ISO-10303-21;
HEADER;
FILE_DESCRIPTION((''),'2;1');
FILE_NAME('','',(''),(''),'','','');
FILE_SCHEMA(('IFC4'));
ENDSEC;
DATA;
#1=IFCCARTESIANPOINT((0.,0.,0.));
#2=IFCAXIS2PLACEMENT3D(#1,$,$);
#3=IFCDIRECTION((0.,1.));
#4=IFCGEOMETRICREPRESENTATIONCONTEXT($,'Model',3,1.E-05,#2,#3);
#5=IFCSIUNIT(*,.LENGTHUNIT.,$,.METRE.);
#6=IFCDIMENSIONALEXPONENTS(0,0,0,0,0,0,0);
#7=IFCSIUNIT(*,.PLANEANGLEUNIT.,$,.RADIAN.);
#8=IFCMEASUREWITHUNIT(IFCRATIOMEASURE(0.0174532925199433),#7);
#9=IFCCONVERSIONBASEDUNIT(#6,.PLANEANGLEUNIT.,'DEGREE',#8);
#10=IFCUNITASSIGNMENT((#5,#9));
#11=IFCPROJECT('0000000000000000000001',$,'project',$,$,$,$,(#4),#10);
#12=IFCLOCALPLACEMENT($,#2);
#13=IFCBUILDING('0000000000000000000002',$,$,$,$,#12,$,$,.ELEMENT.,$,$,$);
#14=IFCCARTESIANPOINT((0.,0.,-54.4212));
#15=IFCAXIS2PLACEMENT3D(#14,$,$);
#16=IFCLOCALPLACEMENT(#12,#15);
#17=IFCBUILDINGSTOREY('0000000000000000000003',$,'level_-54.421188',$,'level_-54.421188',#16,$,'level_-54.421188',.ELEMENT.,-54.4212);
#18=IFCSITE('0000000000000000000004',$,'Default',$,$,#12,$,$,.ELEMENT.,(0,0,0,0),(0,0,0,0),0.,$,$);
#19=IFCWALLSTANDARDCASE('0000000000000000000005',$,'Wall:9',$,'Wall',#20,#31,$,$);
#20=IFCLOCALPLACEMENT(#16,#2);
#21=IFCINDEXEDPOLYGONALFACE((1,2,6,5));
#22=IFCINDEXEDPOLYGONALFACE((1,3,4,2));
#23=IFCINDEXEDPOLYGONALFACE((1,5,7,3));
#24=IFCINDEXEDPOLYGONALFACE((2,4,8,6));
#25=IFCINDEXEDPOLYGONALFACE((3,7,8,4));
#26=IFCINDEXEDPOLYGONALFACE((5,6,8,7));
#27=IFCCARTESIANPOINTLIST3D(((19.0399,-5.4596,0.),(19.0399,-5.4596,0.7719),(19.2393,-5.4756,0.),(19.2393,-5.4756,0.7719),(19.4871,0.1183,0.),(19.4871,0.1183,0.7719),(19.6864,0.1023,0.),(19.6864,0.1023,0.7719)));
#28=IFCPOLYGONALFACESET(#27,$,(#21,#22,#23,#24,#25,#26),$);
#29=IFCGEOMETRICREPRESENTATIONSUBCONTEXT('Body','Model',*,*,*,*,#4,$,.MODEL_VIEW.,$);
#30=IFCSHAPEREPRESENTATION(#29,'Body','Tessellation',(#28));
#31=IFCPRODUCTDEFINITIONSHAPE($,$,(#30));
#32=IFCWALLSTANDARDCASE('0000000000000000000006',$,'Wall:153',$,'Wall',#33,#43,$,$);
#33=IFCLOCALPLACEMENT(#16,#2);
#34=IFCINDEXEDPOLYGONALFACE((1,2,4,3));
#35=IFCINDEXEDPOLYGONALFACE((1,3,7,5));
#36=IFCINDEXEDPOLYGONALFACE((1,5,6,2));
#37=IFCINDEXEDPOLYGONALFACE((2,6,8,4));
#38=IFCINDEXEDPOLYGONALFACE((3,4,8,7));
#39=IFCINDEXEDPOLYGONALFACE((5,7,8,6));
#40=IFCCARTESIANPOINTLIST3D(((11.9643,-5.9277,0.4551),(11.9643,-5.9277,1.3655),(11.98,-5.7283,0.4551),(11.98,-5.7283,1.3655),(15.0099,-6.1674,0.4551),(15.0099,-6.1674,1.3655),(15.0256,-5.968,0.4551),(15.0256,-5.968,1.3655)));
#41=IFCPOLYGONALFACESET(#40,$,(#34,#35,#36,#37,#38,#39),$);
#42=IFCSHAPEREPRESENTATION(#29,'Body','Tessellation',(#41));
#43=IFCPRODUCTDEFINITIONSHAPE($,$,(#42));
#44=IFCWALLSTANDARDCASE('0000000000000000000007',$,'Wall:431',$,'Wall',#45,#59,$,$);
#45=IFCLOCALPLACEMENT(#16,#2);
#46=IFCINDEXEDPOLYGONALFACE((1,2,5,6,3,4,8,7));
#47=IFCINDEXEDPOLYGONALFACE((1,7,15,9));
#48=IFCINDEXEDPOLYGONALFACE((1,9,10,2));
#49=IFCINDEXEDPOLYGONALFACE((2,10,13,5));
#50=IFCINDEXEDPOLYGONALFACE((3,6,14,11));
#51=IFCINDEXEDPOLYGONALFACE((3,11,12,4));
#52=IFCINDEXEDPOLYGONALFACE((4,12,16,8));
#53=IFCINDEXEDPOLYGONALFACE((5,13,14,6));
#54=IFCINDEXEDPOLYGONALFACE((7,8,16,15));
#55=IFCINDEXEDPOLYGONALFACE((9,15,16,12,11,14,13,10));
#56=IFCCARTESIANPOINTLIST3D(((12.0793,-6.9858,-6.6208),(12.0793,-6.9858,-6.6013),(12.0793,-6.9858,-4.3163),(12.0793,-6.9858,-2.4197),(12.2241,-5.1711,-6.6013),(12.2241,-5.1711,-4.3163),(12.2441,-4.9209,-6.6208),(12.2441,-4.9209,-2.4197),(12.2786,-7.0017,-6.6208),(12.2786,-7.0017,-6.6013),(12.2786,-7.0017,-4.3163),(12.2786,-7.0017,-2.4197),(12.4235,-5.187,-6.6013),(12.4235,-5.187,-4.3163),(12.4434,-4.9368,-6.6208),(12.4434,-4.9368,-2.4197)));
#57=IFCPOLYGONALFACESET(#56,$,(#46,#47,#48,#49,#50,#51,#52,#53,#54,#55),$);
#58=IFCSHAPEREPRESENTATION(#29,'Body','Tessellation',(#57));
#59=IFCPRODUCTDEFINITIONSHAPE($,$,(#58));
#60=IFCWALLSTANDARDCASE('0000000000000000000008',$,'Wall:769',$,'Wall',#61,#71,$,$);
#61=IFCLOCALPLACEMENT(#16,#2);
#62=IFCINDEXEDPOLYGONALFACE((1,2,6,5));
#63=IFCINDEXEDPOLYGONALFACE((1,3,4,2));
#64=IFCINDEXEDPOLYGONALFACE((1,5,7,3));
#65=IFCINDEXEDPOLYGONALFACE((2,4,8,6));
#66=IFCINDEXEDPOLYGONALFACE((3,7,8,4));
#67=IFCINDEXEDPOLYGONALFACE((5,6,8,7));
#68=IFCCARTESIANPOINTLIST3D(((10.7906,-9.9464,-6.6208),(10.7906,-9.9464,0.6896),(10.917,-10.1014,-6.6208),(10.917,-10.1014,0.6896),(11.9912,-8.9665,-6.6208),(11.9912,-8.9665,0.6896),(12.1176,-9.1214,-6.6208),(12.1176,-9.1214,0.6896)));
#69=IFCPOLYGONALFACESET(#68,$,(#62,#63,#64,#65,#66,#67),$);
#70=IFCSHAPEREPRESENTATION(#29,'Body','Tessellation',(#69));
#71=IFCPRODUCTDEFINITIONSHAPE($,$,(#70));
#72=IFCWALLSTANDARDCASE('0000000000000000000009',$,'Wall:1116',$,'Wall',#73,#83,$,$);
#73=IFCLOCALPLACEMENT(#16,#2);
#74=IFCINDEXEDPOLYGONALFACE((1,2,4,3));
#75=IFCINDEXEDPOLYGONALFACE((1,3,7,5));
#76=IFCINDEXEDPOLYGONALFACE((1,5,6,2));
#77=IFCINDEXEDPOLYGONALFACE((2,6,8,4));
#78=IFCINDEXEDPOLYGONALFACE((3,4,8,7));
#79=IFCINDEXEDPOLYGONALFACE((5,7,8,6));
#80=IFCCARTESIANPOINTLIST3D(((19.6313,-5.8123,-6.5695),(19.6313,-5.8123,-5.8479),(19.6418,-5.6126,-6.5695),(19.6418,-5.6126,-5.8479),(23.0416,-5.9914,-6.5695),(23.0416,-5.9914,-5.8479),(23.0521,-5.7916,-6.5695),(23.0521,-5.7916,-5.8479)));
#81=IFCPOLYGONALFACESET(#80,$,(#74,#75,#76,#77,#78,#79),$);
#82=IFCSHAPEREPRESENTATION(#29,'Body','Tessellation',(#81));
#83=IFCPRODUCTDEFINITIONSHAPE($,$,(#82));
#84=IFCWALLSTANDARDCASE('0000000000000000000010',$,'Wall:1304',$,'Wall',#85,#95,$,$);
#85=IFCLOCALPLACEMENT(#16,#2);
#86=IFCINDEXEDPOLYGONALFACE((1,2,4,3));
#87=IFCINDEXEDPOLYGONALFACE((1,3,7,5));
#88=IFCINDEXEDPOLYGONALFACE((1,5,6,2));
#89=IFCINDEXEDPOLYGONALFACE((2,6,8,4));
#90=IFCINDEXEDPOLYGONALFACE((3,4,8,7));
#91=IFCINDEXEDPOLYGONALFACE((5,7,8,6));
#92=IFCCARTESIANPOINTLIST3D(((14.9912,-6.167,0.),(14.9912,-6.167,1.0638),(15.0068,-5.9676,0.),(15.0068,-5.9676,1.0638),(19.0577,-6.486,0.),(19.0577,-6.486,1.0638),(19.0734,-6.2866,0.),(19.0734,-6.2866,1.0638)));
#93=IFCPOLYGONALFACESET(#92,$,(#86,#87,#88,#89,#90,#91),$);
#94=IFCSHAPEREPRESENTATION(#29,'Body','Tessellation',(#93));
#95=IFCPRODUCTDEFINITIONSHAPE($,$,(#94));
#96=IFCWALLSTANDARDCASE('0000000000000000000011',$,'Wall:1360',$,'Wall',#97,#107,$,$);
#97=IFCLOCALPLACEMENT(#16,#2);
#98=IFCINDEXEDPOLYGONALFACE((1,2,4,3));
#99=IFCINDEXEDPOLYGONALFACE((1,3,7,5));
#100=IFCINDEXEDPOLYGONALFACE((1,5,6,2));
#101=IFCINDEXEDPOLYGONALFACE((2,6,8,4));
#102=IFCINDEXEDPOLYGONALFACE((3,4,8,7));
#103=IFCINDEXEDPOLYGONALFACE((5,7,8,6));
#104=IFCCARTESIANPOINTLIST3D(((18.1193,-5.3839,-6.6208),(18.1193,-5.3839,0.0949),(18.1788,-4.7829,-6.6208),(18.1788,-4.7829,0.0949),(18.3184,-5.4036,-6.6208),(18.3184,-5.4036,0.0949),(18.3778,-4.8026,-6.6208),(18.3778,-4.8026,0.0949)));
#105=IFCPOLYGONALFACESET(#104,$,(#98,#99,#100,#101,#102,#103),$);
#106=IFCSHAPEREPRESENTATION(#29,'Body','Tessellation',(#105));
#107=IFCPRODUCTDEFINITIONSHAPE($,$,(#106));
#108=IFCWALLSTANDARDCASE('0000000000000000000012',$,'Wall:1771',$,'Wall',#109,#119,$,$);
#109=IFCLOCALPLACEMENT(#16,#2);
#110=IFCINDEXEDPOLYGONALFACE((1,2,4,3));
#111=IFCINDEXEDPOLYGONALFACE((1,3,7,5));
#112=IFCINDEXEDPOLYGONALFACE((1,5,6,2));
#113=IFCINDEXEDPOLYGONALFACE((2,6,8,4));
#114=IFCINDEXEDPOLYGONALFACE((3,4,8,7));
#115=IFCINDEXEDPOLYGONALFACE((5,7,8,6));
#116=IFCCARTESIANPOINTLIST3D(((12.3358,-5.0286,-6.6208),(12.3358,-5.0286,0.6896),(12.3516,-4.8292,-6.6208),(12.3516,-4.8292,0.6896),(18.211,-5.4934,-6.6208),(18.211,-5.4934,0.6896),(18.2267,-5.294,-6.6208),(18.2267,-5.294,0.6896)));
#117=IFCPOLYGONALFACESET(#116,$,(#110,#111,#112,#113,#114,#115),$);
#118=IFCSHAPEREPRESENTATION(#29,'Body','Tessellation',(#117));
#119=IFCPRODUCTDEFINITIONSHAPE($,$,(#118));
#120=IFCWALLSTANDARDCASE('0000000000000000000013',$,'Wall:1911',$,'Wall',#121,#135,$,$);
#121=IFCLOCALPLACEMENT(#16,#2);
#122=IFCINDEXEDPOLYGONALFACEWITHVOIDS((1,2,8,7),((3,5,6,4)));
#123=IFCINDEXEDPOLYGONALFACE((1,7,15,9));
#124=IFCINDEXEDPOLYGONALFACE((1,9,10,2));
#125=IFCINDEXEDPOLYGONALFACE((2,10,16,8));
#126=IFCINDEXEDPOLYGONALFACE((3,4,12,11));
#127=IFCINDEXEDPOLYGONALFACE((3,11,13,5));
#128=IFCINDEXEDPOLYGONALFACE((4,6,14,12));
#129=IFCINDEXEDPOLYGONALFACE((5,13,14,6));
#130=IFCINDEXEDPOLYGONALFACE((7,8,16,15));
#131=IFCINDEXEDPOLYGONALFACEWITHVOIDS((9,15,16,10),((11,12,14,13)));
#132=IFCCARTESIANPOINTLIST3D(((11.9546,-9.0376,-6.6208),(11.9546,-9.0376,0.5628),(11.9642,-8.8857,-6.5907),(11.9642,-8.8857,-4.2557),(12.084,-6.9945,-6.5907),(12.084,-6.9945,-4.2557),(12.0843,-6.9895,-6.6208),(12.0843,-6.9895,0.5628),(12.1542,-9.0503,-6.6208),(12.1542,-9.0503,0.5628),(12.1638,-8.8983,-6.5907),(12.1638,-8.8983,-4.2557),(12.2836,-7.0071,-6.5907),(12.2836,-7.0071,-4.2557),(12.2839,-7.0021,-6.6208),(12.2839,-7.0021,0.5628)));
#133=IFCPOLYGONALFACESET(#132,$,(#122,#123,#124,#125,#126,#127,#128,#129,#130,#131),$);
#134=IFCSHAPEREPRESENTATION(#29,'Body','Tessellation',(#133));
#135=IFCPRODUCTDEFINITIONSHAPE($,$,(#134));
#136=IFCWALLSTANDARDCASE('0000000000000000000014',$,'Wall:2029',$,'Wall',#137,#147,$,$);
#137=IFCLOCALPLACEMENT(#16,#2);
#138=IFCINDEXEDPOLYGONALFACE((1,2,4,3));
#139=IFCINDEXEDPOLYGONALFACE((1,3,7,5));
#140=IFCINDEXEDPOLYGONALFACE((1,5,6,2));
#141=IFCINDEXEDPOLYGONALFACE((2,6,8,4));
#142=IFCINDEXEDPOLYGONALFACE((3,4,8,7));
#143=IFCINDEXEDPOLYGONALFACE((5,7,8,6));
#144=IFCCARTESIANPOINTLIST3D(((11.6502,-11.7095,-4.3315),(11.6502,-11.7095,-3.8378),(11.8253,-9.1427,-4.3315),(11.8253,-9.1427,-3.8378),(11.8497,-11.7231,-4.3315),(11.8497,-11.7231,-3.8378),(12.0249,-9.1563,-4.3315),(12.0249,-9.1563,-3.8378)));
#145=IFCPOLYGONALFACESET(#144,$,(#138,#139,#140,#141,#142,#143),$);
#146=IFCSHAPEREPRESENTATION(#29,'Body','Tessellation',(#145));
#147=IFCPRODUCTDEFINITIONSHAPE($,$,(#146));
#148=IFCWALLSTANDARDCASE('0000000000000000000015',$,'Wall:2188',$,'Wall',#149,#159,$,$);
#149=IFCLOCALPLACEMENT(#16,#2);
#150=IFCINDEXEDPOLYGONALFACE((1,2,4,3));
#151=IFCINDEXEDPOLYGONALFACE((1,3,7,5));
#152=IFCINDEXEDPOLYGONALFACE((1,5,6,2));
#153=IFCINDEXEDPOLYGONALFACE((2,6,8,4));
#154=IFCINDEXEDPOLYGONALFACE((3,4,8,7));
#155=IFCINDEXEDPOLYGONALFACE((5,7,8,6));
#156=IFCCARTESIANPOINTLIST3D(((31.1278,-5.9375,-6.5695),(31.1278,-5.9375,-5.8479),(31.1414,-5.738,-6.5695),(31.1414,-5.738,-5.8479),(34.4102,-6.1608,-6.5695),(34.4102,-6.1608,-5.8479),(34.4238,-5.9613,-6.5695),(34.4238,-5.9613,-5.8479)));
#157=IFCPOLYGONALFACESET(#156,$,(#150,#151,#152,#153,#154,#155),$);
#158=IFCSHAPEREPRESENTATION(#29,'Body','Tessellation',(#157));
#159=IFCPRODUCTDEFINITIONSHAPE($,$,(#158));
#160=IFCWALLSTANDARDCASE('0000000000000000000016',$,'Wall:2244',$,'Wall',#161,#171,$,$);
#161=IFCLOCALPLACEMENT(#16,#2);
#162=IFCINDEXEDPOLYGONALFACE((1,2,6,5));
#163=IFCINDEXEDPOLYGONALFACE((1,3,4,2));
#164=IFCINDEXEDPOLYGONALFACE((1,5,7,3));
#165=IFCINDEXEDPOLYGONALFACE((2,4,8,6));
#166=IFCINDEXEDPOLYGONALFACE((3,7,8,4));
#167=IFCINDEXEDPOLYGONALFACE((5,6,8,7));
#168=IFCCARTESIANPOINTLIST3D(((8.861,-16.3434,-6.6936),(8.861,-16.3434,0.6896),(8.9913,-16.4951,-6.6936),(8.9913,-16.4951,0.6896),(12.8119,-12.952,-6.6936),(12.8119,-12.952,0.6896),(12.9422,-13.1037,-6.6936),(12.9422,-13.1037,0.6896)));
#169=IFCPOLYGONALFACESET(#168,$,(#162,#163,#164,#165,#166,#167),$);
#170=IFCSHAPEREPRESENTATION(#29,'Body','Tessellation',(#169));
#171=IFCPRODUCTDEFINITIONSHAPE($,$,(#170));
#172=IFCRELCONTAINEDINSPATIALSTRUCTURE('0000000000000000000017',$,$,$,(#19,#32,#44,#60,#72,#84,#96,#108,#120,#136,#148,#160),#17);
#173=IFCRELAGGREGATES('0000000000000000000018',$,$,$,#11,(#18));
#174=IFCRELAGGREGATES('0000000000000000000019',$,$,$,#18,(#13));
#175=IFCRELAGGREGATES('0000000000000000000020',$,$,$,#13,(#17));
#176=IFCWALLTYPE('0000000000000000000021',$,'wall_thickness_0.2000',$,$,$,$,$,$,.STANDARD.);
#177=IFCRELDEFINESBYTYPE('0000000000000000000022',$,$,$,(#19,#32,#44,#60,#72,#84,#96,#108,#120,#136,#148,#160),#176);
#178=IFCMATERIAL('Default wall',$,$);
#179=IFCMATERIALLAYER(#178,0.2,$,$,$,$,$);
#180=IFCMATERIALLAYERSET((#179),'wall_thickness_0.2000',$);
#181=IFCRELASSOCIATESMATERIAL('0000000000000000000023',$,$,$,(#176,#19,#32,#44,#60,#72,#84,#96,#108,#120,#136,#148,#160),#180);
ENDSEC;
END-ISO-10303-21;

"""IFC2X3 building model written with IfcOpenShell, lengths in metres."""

from ifc_helpers import new_model, entity, si_unit, converted_unit, direction, frame, frame_2d, origin, place, context, subcontext, project, spatial, polyline, rectangle, outline, extrude, material, layer, layer_set, layer_usage, type_object, element, save


model = new_model("IFC2X3")

# Units and contexts
model_context = context("Model", 3, precision=1e-05, world=origin(), true_north=direction((0.0, 1.0)))
body_context = subcontext(model_context, "Body", "Model", "MODEL_VIEW")
ifc_project = project(units=[si_unit("LENGTHUNIT", "METRE"), converted_unit("PLANEANGLEUNIT", "DEGREE", entity("IfcRatioMeasure", 0.0174532925199433), si_unit("PLANEANGLEUNIT", "RADIAN"), dimensions=[0, 0, 0, 0, 0, 0, 0])], contexts=[model_context])

# Site, building, storey
placement_1 = place(None, origin())
site = spatial("IfcSite", under=ifc_project, at=placement_1, Name="Default", CompositionType="ELEMENT", RefLatitude=(0, 0, 0, 0), RefLongitude=(0, 0, 0, 0), RefElevation=0.0)
building = spatial("IfcBuilding", under=site, at=placement_1, CompositionType="ELEMENT")
storey_placement = place(placement_1, frame((0.0, 0.0, -54.4212)))
storey = spatial("IfcBuildingStorey", under=building, at=storey_placement, Name="level_-54.421188", ObjectType="level_-54.421188", LongName="level_-54.421188", CompositionType="ELEMENT", Elevation=-54.4212)

# Walls
ifc_material = material(Name="Default wall")
ifc_layer = layer(ifc_material, 0.2)
ifc_layer_set = layer_set([ifc_layer], Name="wall_thickness_0.2000")
ifc_layer_usage = layer_usage(ifc_layer_set, "AXIS2", "POSITIVE", -0.1)
wall_type = type_object("IfcWallType", Name="wall_thickness_0.2000", PredefinedType="STANDARD", material=ifc_layer_set)
wall_1_placement = place(storey_placement, frame((19.1396, -5.4676, 0.0), z_axis=(0.0, 0.0, 1.0), x_axis=(0.079906, 0.996802, 0.0)))
element("IfcWallStandardCase", 1, at=wall_1_placement, inside=storey, type_object=wall_type, material=ifc_layer_usage, Name="Wall:9", ObjectType="Wall", context=body_context, shape_type="SweptSolid", body=[
    extrude(outline(polyline([(5.5958, -0.1), (5.5958, 0.1), (0.0, 0.1), (0.0, -0.1), (5.5958, -0.1)])), origin(), (0.0, 0.0, 1.0), 0.7719),
])
placement_2 = place(placement_1, frame((0.0, 0.0, -53.9661)))
wall_2_placement = place(placement_2, frame((11.9722, -5.828, 0.0), z_axis=(0.0, 0.0, 1.0), x_axis=(0.996917, -0.07846, 0.0)))
element("IfcWallStandardCase", 2, at=wall_2_placement, inside=storey, type_object=wall_type, material=ifc_layer_usage, Name="Wall:153", ObjectType="Wall", context=body_context, shape_type="SweptSolid", body=[
    extrude(outline(polyline([(3.055, -0.1), (3.055, 0.1), (0.0, 0.1), (0.0, -0.1), (3.055, -0.1)])), origin(), (0.0, 0.0, 1.0), 0.9104),
])

# Wall, opening
placement_3 = place(placement_1, frame((0.0, 0.0, -61.042)))
wall_3_placement = place(placement_3, frame((12.3437, -4.9289, 0.0), z_axis=(0.0, 0.0, 1.0), x_axis=(-0.079545, -0.996831, 0.0)))
wall_3 = element("IfcWallStandardCase", 3, at=wall_3_placement, inside=storey, type_object=wall_type, material=ifc_layer_usage, Name="Wall:431", ObjectType="Wall", context=body_context, shape_type="SweptSolid", body=[
    extrude(outline(polyline([(2.0715, -0.1), (2.0715, 0.1), (0.0, 0.1), (0.0, -0.1), (2.0715, -0.1)])), origin(), (0.0, 0.0, 1.0), 4.2012),
])
opening_1_placement = place(wall_3_placement, frame((0.2509, -0.1, 0.0196)))
element("IfcOpeningElement", 4, at=opening_1_placement, cuts=wall_3, ObjectType="Opening", context=body_context, shape_type="SweptSolid", body=[
    extrude(rectangle(XDim=1.87, YDim=2.285, at=frame_2d((1.1425, 0.935), x_axis=(0.0, 1.0))), frame((0.0, 0.0, 0.0), z_axis=(0.0, 1.0, 0.0), x_axis=(0.0, 0.0, 1.0)), (0.0, 0.0, 1.0), 0.2),
])

# Walls
placement_4 = place(placement_1, frame((0.0, 0.0, -61.042)))
wall_4_placement = place(placement_4, frame((12.0544, -9.0439, 0.0), z_axis=(0.0, 0.0, 1.0), x_axis=(-0.774696, -0.632333, 0.0)))
element("IfcWallStandardCase", 5, at=wall_4_placement, inside=storey, type_object=wall_type, material=ifc_layer_usage, Name="Wall:769", ObjectType="Wall", context=body_context, shape_type="SweptSolid", body=[
    extrude(outline(polyline([(1.5498, -0.1), (1.5498, 0.1), (0.0, 0.1), (0.0, -0.1), (1.5498, -0.1)])), origin(), (0.0, 0.0, 1.0), 7.3104),
])
placement_5 = place(placement_1, frame((0.0, 0.0, -60.9907)))
wall_5_placement = place(placement_5, frame((19.6365, -5.7125, 0.0), z_axis=(0.0, 0.0, 1.0), x_axis=(0.998625, -0.052423, 0.0)))
element("IfcWallStandardCase", 6, at=wall_5_placement, inside=storey, type_object=wall_type, material=ifc_layer_usage, Name="Wall:1116", ObjectType="Wall", context=body_context, shape_type="SweptSolid", body=[
    extrude(outline(polyline([(3.415, -0.1), (3.415, 0.1), (0.0, 0.1), (0.0, -0.1), (3.415, -0.1)])), origin(), (0.0, 0.0, 1.0), 0.7215),
])
wall_6_placement = place(storey_placement, frame((14.999, -6.0673, 0.0), z_axis=(0.0, 0.0, 1.0), x_axis=(0.996939, -0.078189, 0.0)))
element("IfcWallStandardCase", 7, at=wall_6_placement, inside=storey, type_object=wall_type, material=ifc_layer_usage, Name="Wall:1304", ObjectType="Wall", context=body_context, shape_type="SweptSolid", body=[
    extrude(outline(polyline([(4.079, -0.1), (4.079, 0.1), (0.0, 0.1), (0.0, -0.1), (4.079, -0.1)])), origin(), (0.0, 0.0, 1.0), 1.0638),
])
placement_6 = place(placement_1, frame((0.0, 0.0, -61.042)))
wall_7_placement = place(placement_6, frame((18.2189, -5.3937, 0.0), z_axis=(0.0, 0.0, 1.0), x_axis=(0.098501, 0.995137, 0.0)))
element("IfcWallStandardCase", 8, at=wall_7_placement, inside=storey, type_object=wall_type, material=ifc_layer_usage, Name="Wall:1360", ObjectType="Wall", context=body_context, shape_type="SweptSolid", body=[
    extrude(outline(polyline([(0.6039, -0.1), (0.6039, 0.1), (0.0, 0.1), (0.0, -0.1), (0.6039, -0.1)])), origin(), (0.0, 0.0, 1.0), 6.7157),
])
placement_7 = place(placement_1, frame((0.0, 0.0, -61.042)))
wall_8_placement = place(placement_7, frame((18.2188, -5.3937, 0.0), z_axis=(0.0, 0.0, 1.0), x_axis=(-0.996885, 0.078873, 0.0)))
element("IfcWallStandardCase", 9, at=wall_8_placement, inside=storey, type_object=wall_type, material=ifc_layer_usage, Name="Wall:1771", ObjectType="Wall", context=body_context, shape_type="SweptSolid", body=[
    extrude(outline(polyline([(5.8935, -0.1), (5.8935, 0.1), (0.0, 0.1), (0.0, -0.1), (5.8935, -0.1)])), origin(), (0.0, 0.0, 1.0), 7.3104),
])

# Wall, opening
placement_8 = place(placement_1, frame((0.0, 0.0, -61.042)))
wall_9_placement = place(placement_8, frame((12.1841, -6.9958, 0.0), z_axis=(0.0, 0.0, 1.0), x_axis=(-0.063192, -0.998001, 0.0)))
wall_9 = element("IfcWallStandardCase", 10, at=wall_9_placement, inside=storey, type_object=wall_type, material=ifc_layer_usage, Name="Wall:1911", ObjectType="Wall", context=body_context, shape_type="SweptSolid", body=[
    extrude(outline(polyline([(2.0522, -0.1), (2.0522, 0.1), (0.0, 0.1), (0.0, -0.1), (2.0522, -0.1)])), origin(), (0.0, 0.0, 1.0), 7.1836),
])
opening_2_placement = place(wall_9_placement, frame((0.005, -0.1, 0.0301)))
element("IfcOpeningElement", 11, at=opening_2_placement, cuts=wall_9, ObjectType="Opening", context=body_context, shape_type="SweptSolid", body=[
    extrude(rectangle(XDim=1.895, YDim=2.335, at=frame_2d((1.1675, 0.9475), x_axis=(0.0, 1.0))), frame((0.0, 0.0, 0.0), z_axis=(0.0, 1.0, 0.0), x_axis=(0.0, 0.0, 1.0)), (0.0, 0.0, 1.0), 0.2),
])

# Walls
placement_9 = place(placement_1, frame((0.0, 0.0, -58.7527)))
wall_10_placement = place(placement_9, frame((11.7499, -11.7163, 0.0), z_axis=(0.0, 0.0, 1.0), x_axis=(0.068078, 0.99768, 0.0)))
element("IfcWallStandardCase", 12, at=wall_10_placement, inside=storey, type_object=wall_type, material=ifc_layer_usage, Name="Wall:2029", ObjectType="Wall", context=body_context, shape_type="SweptSolid", body=[
    extrude(outline(polyline([(2.5728, -0.1), (2.5728, 0.1), (0.0, 0.1), (0.0, -0.1), (2.5728, -0.1)])), origin(), (0.0, 0.0, 1.0), 0.4937),
])
placement_10 = place(placement_1, frame((0.0, 0.0, -60.9907)))
wall_11_placement = place(placement_10, frame((31.1346, -5.8377, 0.0), z_axis=(0.0, 0.0, 1.0), x_axis=(0.997694, -0.067877, 0.0)))
element("IfcWallStandardCase", 13, at=wall_11_placement, inside=storey, type_object=wall_type, material=ifc_layer_usage, Name="Wall:2188", ObjectType="Wall", context=body_context, shape_type="SweptSolid", body=[
    extrude(outline(polyline([(3.29, -0.1), (3.29, 0.1), (0.0, 0.1), (0.0, -0.1), (3.29, -0.1)])), origin(), (0.0, 0.0, 1.0), 0.7215),
])
placement_11 = place(placement_1, frame((0.0, 0.0, -61.1148)))
wall_12_placement = place(placement_11, frame((12.877, -13.0278, 0.0), z_axis=(0.0, 0.0, 1.0), x_axis=(-0.75879, -0.651335, 0.0)))
element("IfcWallStandardCase", 14, at=wall_12_placement, inside=storey, type_object=wall_type, material=ifc_layer_usage, Name="Wall:2244", ObjectType="Wall", context=body_context, shape_type="SweptSolid", body=[
    extrude(outline(polyline([(5.2068, -0.1), (5.2068, 0.1), (0.0, 0.1), (0.0, -0.1), (5.2068, -0.1)])), origin(), (0.0, 0.0, 1.0), 7.3832),
])

save(model, "model.ifc")
